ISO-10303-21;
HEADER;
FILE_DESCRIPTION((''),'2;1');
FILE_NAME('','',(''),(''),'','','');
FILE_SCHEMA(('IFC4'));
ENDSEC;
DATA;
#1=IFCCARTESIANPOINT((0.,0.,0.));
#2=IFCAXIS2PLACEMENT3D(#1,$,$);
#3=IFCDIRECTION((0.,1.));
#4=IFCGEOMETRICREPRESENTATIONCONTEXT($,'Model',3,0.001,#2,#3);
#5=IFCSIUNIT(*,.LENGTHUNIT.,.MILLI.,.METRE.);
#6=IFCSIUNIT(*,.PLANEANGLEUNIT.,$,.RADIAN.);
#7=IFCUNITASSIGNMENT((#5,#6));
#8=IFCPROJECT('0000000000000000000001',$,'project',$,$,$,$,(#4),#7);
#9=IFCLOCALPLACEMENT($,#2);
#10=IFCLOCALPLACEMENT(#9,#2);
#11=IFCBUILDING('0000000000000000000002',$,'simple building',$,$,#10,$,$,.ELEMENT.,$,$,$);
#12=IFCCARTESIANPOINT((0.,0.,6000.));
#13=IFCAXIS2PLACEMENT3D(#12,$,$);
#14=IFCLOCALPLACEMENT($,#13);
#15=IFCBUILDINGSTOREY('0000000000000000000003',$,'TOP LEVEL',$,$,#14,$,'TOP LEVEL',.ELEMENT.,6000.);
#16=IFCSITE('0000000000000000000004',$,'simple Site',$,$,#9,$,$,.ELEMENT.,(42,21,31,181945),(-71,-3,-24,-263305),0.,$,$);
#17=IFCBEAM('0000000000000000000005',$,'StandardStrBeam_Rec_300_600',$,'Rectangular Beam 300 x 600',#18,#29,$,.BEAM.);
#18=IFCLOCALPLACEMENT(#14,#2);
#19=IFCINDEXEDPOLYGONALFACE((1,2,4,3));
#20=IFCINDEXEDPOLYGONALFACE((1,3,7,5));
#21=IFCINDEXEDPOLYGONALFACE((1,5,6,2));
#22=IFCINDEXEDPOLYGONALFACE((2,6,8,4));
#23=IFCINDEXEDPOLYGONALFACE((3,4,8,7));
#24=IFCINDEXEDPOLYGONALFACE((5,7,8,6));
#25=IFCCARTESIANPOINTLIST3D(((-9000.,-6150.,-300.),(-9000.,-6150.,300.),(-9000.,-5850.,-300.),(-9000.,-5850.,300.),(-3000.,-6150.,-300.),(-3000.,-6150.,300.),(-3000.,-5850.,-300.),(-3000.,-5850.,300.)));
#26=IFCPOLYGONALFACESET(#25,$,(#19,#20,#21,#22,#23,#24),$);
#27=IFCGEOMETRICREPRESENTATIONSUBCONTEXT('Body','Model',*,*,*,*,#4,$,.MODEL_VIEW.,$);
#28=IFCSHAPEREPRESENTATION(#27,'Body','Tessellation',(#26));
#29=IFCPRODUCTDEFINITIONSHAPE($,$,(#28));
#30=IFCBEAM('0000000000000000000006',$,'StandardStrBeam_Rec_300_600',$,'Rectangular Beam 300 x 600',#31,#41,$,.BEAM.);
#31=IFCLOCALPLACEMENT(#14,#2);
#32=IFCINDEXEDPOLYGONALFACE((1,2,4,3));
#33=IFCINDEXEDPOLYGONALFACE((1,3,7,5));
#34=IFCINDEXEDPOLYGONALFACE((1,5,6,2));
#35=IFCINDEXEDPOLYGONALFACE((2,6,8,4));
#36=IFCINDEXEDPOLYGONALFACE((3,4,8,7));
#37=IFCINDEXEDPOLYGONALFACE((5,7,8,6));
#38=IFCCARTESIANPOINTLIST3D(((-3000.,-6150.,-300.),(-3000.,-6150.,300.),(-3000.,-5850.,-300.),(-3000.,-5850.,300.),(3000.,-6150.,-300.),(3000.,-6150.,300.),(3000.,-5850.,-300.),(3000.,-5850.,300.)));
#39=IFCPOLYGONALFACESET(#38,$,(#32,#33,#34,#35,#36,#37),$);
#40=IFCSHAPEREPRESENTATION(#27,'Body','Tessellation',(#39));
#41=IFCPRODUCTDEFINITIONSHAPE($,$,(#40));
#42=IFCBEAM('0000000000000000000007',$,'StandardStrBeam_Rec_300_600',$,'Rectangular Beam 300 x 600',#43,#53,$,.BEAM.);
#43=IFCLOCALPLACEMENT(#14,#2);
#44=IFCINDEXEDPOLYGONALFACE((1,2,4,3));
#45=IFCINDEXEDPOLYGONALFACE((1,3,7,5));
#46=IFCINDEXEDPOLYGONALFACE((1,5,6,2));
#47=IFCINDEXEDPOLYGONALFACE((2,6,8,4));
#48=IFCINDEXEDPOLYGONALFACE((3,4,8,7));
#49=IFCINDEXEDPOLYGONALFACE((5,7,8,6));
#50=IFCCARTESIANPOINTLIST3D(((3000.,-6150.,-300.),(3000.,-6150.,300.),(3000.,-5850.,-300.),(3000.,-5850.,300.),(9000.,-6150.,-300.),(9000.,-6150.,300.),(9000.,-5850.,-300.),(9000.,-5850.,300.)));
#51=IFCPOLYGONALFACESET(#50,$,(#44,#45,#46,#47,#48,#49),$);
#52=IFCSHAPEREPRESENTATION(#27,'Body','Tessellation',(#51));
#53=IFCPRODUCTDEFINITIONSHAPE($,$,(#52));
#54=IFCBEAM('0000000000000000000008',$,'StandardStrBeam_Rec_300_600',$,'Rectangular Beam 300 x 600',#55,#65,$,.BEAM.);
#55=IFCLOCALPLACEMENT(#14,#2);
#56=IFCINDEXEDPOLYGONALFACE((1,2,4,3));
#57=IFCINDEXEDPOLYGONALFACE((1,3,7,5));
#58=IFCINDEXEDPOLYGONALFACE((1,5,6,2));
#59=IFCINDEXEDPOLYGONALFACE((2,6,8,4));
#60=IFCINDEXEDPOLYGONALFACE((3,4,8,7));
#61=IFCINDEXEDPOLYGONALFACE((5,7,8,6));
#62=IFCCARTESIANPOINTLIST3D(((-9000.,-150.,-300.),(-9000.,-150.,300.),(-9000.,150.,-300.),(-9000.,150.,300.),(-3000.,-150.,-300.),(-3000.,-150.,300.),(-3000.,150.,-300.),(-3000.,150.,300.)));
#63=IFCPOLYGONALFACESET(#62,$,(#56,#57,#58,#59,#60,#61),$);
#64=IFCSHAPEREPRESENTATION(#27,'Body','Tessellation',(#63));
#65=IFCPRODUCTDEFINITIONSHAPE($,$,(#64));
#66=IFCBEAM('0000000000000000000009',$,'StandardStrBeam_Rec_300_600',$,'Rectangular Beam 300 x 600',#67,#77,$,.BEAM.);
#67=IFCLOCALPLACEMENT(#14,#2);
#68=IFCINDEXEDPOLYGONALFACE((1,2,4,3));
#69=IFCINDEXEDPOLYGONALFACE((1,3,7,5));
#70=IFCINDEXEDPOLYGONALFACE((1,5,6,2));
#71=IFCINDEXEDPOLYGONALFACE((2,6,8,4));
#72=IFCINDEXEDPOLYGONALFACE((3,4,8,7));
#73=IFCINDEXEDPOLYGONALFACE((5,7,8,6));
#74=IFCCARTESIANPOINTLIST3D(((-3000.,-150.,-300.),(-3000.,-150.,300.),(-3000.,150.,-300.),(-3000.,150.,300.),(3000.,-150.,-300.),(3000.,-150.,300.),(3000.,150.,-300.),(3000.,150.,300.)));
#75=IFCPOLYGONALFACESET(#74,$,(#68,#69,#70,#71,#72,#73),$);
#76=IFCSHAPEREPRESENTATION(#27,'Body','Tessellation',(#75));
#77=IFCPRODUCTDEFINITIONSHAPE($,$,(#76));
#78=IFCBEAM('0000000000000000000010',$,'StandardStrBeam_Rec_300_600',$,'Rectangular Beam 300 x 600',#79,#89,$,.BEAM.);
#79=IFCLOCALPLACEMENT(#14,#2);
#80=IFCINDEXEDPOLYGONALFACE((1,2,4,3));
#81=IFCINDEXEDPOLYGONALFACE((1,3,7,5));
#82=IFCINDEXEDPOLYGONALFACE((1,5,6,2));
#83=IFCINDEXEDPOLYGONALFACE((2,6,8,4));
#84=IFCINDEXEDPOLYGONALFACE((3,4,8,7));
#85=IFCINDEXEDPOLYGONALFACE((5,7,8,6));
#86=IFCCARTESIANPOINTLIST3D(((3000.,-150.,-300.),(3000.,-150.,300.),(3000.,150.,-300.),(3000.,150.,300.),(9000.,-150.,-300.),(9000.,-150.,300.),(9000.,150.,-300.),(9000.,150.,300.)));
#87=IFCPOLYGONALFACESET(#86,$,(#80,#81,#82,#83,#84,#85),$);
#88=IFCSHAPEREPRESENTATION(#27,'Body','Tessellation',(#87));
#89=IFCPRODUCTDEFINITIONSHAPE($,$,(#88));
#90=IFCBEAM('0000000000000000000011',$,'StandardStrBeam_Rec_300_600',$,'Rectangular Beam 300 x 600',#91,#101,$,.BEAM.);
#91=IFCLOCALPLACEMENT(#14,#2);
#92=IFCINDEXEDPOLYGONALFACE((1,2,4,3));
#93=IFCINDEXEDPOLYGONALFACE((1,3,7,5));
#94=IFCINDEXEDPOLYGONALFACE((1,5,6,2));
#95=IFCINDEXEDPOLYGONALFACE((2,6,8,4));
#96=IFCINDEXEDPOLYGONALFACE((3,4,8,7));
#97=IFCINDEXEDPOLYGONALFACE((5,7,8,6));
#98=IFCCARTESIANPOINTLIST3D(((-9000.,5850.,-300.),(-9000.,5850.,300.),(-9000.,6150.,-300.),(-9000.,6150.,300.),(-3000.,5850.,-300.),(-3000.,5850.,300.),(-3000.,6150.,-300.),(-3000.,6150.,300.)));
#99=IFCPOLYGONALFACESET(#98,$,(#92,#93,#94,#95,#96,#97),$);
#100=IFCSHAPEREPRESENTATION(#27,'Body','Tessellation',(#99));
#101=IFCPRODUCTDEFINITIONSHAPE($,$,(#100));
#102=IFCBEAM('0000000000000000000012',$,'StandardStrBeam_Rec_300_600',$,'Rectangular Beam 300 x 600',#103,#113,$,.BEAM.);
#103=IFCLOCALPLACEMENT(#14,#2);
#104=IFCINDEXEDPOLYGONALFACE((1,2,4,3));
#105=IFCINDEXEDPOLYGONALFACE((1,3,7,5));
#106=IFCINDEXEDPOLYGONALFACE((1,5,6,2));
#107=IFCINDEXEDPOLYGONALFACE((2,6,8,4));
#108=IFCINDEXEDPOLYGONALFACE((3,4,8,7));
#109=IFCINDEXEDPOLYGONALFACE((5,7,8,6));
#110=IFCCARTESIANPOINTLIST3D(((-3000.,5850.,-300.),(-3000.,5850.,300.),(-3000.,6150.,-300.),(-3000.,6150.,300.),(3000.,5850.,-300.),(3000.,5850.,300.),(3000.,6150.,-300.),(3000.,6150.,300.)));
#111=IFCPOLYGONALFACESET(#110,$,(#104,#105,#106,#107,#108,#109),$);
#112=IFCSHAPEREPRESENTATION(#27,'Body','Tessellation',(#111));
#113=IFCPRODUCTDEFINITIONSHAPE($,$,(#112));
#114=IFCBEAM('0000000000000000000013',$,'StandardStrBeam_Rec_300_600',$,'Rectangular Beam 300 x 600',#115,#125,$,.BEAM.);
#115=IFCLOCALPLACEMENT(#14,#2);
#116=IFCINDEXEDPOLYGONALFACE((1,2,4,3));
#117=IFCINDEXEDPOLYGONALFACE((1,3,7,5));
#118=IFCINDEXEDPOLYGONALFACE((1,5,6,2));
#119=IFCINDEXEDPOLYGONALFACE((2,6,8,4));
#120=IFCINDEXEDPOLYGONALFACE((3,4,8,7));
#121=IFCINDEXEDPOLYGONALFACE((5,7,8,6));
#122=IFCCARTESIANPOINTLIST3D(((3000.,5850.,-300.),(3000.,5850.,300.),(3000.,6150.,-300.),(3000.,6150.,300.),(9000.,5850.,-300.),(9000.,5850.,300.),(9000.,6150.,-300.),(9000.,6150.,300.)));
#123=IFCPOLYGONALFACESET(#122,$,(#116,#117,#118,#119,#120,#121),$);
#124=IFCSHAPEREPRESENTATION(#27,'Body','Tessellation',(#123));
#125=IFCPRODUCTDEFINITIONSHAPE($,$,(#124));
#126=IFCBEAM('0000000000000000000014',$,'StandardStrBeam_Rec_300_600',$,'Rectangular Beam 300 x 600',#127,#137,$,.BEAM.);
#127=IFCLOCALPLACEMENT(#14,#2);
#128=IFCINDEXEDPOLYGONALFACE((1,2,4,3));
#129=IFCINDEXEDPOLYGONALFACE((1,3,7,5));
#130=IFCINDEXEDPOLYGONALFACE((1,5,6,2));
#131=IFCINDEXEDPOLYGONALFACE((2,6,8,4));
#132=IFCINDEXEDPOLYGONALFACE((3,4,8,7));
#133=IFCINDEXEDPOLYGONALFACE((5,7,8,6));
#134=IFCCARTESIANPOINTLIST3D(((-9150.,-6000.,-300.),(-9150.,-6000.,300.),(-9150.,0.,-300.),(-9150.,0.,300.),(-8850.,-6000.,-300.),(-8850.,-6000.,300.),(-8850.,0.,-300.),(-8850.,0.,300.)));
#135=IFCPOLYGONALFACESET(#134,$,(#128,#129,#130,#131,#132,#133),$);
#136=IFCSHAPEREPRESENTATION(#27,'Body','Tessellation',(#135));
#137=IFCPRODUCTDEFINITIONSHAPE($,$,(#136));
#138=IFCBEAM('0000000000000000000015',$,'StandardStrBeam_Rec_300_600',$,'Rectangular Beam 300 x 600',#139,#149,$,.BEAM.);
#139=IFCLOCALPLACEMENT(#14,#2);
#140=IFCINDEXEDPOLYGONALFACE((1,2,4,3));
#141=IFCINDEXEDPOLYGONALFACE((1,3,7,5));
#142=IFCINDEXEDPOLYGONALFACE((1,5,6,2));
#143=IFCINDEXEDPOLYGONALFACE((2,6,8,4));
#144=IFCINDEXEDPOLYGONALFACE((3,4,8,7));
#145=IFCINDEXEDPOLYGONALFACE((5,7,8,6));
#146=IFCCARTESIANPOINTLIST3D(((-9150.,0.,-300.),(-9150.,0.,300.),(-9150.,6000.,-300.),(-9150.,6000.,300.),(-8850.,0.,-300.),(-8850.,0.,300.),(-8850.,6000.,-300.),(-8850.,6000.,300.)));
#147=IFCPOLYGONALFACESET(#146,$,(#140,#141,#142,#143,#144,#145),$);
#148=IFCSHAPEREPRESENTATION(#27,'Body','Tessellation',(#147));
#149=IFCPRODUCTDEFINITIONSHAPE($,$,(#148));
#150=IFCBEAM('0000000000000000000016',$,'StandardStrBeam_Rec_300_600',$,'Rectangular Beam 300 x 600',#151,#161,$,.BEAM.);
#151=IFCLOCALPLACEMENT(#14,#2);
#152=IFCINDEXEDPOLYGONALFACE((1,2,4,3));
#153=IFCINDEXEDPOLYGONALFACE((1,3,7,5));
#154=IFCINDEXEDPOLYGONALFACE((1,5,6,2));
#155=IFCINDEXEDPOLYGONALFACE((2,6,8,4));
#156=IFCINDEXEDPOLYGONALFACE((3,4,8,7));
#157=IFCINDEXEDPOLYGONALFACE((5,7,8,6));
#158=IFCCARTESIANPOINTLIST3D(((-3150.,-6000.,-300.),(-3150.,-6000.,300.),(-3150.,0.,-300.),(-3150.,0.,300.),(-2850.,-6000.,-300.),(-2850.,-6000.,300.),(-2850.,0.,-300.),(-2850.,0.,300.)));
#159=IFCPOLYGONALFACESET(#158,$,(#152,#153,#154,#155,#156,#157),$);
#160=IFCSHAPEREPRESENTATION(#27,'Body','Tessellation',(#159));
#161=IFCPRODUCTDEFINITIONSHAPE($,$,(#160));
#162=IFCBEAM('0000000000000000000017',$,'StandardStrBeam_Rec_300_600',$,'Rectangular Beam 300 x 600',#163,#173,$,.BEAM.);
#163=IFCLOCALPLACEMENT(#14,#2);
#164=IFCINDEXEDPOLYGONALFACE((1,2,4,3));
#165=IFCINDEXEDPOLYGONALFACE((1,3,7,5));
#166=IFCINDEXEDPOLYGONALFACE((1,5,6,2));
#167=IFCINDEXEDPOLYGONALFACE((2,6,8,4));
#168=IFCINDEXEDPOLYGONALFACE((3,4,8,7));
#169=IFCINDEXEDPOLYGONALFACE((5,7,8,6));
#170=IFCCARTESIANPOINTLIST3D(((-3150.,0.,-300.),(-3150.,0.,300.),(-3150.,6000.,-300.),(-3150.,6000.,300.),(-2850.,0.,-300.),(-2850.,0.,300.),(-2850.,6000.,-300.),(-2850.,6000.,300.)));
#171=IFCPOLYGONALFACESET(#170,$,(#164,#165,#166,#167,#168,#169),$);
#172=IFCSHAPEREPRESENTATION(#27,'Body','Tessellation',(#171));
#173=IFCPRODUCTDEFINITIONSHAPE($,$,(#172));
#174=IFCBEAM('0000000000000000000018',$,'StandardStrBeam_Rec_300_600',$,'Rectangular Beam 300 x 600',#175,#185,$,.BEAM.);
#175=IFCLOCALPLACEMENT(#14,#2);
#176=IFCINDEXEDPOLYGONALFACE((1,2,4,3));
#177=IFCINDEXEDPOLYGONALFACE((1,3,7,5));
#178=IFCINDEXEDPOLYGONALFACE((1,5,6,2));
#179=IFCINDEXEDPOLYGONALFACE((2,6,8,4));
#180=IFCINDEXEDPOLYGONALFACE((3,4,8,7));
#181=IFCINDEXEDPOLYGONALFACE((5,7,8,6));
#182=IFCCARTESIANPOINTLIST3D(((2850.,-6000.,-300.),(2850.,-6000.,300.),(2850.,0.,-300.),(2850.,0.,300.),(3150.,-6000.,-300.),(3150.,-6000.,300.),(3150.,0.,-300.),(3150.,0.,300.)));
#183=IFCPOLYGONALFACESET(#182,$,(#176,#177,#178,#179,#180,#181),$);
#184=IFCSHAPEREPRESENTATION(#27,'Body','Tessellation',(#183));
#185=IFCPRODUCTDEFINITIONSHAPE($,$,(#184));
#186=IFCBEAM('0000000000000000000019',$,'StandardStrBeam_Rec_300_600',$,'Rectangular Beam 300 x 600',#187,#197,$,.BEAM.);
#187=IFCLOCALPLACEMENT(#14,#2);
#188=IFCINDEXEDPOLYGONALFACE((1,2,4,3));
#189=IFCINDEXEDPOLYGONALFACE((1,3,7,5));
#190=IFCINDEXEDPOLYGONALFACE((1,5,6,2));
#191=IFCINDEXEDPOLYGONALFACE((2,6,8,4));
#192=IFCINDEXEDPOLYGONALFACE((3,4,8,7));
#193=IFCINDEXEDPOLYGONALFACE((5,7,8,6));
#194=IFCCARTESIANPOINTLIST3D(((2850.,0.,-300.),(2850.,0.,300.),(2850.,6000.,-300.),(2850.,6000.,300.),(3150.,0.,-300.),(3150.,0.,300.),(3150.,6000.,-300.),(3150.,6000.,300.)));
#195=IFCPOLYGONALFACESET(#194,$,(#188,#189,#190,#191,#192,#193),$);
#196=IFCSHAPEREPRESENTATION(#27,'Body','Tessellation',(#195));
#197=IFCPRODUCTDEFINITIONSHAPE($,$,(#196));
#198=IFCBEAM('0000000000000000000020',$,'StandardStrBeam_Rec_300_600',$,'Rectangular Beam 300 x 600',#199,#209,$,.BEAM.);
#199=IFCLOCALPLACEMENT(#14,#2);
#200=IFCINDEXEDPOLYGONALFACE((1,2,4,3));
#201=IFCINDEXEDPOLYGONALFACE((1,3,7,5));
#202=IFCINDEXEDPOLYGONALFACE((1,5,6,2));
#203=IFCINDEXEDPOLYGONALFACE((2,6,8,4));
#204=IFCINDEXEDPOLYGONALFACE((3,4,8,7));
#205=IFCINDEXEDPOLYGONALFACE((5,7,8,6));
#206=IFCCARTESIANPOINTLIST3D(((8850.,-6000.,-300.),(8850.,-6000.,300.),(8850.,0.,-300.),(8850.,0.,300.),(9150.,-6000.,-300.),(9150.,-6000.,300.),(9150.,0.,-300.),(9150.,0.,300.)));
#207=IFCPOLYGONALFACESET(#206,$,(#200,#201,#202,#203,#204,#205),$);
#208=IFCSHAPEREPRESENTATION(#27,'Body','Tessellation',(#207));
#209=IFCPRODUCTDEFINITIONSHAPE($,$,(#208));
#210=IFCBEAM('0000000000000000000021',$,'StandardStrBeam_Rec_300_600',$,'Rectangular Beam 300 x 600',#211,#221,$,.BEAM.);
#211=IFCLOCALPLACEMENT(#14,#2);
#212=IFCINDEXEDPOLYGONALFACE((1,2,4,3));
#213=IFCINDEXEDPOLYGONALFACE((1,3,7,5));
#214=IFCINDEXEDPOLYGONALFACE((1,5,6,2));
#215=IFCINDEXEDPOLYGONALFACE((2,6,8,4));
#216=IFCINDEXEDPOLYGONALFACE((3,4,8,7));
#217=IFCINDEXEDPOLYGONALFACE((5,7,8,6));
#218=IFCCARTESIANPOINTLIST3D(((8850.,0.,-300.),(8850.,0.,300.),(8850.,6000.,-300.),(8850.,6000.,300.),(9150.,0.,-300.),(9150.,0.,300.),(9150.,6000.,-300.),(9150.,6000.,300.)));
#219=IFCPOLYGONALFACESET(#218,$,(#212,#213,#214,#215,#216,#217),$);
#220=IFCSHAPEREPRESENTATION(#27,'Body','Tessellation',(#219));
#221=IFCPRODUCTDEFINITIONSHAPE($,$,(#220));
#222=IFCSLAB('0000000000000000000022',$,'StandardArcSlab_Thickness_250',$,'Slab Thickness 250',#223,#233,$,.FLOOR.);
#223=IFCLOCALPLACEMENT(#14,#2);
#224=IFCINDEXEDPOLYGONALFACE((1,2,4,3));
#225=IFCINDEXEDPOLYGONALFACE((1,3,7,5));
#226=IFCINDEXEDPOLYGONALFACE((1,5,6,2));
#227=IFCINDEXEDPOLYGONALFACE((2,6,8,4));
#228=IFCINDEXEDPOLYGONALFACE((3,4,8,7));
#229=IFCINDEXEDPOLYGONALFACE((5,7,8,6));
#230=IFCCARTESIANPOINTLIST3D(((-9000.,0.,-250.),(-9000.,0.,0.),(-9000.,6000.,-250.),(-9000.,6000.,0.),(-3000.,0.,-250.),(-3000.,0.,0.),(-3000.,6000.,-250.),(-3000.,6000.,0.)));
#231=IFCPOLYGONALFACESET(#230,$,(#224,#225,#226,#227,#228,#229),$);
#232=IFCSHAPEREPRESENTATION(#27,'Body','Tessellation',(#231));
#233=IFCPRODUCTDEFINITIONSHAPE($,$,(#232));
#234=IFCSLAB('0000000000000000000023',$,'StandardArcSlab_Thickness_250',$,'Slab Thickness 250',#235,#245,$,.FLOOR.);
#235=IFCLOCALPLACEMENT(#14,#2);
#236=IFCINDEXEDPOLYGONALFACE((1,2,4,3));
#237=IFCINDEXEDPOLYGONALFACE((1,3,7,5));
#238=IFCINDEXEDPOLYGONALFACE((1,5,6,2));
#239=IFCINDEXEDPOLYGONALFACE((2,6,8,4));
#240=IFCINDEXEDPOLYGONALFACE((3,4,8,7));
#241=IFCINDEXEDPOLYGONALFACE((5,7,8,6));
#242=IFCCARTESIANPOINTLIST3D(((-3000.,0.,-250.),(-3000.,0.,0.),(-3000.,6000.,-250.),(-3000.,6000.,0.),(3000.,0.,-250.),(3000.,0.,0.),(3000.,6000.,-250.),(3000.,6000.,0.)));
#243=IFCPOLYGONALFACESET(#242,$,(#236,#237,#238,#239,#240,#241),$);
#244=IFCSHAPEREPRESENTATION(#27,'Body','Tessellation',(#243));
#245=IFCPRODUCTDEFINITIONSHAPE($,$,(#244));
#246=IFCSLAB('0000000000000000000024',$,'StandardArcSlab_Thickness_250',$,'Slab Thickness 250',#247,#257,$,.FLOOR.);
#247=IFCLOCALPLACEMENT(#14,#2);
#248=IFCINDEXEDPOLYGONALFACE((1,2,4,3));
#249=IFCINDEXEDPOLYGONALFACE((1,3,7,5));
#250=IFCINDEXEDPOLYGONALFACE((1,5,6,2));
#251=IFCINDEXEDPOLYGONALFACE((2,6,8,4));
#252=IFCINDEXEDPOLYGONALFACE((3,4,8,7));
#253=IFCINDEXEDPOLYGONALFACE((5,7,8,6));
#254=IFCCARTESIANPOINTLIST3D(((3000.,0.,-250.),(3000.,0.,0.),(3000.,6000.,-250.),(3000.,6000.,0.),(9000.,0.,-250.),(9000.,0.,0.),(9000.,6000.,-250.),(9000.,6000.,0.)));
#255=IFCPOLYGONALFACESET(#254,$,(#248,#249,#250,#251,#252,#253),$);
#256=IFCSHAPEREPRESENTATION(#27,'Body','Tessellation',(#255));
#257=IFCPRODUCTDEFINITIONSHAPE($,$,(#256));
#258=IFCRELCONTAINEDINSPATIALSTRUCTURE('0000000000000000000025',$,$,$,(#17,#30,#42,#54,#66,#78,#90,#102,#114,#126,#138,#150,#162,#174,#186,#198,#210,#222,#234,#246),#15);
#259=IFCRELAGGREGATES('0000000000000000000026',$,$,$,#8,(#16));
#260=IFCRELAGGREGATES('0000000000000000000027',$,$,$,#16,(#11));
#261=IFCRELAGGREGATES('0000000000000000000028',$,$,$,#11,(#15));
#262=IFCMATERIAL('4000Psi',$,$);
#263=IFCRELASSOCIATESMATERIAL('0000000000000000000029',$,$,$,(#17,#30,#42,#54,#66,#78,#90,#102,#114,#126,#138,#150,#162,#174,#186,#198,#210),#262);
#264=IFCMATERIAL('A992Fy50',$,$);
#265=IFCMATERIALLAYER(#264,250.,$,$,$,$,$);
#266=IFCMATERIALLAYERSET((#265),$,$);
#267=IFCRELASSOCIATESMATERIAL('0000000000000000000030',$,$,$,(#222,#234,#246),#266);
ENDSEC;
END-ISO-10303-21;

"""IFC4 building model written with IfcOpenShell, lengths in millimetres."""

from ifc_helpers import new_model, si_unit, direction, frame, origin, origin_with_axes, origin_2d_with_axis, place, context, subcontext, project, spatial, polyline, rectangle, outline, extrude, material, layer, layer_set, layer_usage, material_profile, profile_set, profile_usage, element, save


model = new_model("IFC4")

# Units and contexts
model_context = context("Model", 3, precision=0.001, world=origin(), true_north=direction((0.0, 1.0)))
body_context = subcontext(model_context, "Body", "Model", "MODEL_VIEW")
ifc_project = project(units=[si_unit("LENGTHUNIT", "METRE", prefix="MILLI"), si_unit("PLANEANGLEUNIT", "RADIAN")], contexts=[model_context])

# Site, building, storey
site_placement = place(None, origin())
site = spatial("IfcSite", under=ifc_project, at=site_placement, Name="simple Site", CompositionType="ELEMENT", RefLatitude=(42, 21, 31, 181945), RefLongitude=(-71, -3, -24, -263305), RefElevation=0.0)
building_placement = place(site_placement, origin())
building = spatial("IfcBuilding", under=site, at=building_placement, Name="simple building", CompositionType="ELEMENT")
storey_placement = place(None, frame((0.0, 0.0, 6000.0)))
storey = spatial("IfcBuildingStorey", under=building, at=storey_placement, Name="TOP LEVEL", LongName="TOP LEVEL", CompositionType="ELEMENT", Elevation=6000.0)

# Beams
ifc_material_1 = material(Name="4000Psi")
ifc_material_profile = material_profile(ifc_material_1, rectangle(XDim=300.0, YDim=600.0, at=origin_2d_with_axis()))
ifc_profile_set = profile_set([ifc_material_profile])
ifc_profile_usage = profile_usage(ifc_profile_set, cardinal=10)
for number, where, z_axis, x_axis, name in (
    (1, (-9000.0, -6000.0, 6000.0), (1.0, 0.0, 0.0), (0.0, -1.0, 0.0), "StandardStrBeam_Rec_300_600"),
    (2, (-3000.0, -6000.0, 6000.0), (1.0, 0.0, 0.0), (0.0, -1.0, 0.0), "StandardStrBeam_Rec_300_600"),
    (3, (3000.0, -6000.0, 6000.0), (1.0, 0.0, 0.0), (0.0, -1.0, 0.0), "StandardStrBeam_Rec_300_600"),
    (4, (-9000.0, 0.0, 6000.0), (1.0, 0.0, 0.0), (0.0, -1.0, 0.0), "StandardStrBeam_Rec_300_600"),
    (5, (-3000.0, 0.0, 6000.0), (1.0, 0.0, 0.0), (0.0, -1.0, 0.0), "StandardStrBeam_Rec_300_600"),
    (6, (3000.0, 0.0, 6000.0), (1.0, 0.0, 0.0), (0.0, -1.0, 0.0), "StandardStrBeam_Rec_300_600"),
    (7, (-9000.0, 6000.0, 6000.0), (1.0, 0.0, 0.0), (0.0, -1.0, 0.0), "StandardStrBeam_Rec_300_600"),
    (8, (-3000.0, 6000.0, 6000.0), (1.0, 0.0, 0.0), (0.0, -1.0, 0.0), "StandardStrBeam_Rec_300_600"),
    (9, (3000.0, 6000.0, 6000.0), (1.0, 0.0, 0.0), (0.0, -1.0, 0.0), "StandardStrBeam_Rec_300_600"),
    (10, (-9000.0, -6000.0, 6000.0), (0.0, 1.0, 0.0), (1.0, 0.0, 0.0), "StandardStrBeam_Rec_300_600"),
    (11, (-9000.0, 0.0, 6000.0), (0.0, 1.0, 0.0), (1.0, 0.0, 0.0), "StandardStrBeam_Rec_300_600"),
    (12, (-3000.0, -6000.0, 6000.0), (0.0, 1.0, 0.0), (1.0, 0.0, 0.0), "StandardStrBeam_Rec_300_600"),
    (13, (-3000.0, 0.0, 6000.0), (0.0, 1.0, 0.0), (1.0, 0.0, 0.0), "StandardStrBeam_Rec_300_600"),
    (14, (3000.0, -6000.0, 6000.0), (0.0, 1.0, 0.0), (1.0, 0.0, 0.0), "StandardStrBeam_Rec_300_600"),
    (15, (3000.0, 0.0, 6000.0), (0.0, 1.0, 0.0), (1.0, 0.0, 0.0), "StandardStrBeam_Rec_300_600"),
    (16, (9000.0, -6000.0, 6000.0), (0.0, 1.0, 0.0), (1.0, 0.0, 0.0), "StandardStrBeam_Rec_300_600"),
    (17, (9000.0, 0.0, 6000.0), (0.0, 1.0, 0.0), (1.0, 0.0, 0.0), "StandardStrBeam_Rec_300_600"),
):
    element("IfcBeam", number, at=place(None, frame(where, z_axis=z_axis, x_axis=x_axis)), inside=storey, material=ifc_profile_usage, Name=name, ObjectType="Rectangular Beam 300 x 600", PredefinedType="BEAM", context=body_context, shape_type="SweptSolid", body=[
        extrude(rectangle(XDim=300.0, YDim=600.0, at=origin_2d_with_axis()), origin_with_axes(), (0.0, 0.0, 1.0), 6000.0),
    ])

# Slabs
ifc_material_2 = material(Name="A992Fy50")
ifc_layer = layer(ifc_material_2, 250.0)
ifc_layer_set = layer_set([ifc_layer])
ifc_layer_usage = layer_usage(ifc_layer_set, "AXIS3", "POSITIVE", -250.0)
for number, where, z_axis, x_axis, name in (
    (18, (-9000.0, 0.0, 5750.0), (0.0, 0.0, 1.0), (1.0, 0.0, 0.0), "StandardArcSlab_Thickness_250"),
    (19, (-3000.0, 0.0, 5750.0), (0.0, 0.0, 1.0), (1.0, 0.0, 0.0), "StandardArcSlab_Thickness_250"),
    (20, (3000.0, 0.0, 5750.0), (0.0, 0.0, 1.0), (1.0, 0.0, 0.0), "StandardArcSlab_Thickness_250"),
):
    element("IfcSlab", number, at=place(None, frame(where, z_axis=z_axis, x_axis=x_axis)), inside=storey, material=ifc_layer_usage, Name=name, ObjectType="Slab Thickness 250", PredefinedType="FLOOR", context=body_context, shape_type="SweptSolid", body=[
        extrude(outline(polyline([(0.0, 0.0), (6000.0, 0.0), (6000.0, 6000.0), (0.0, 6000.0), (0.0, 0.0)])), origin_with_axes(), (0.0, 0.0, 1.0), 250.0),
    ])

save(model, "model.ifc")
